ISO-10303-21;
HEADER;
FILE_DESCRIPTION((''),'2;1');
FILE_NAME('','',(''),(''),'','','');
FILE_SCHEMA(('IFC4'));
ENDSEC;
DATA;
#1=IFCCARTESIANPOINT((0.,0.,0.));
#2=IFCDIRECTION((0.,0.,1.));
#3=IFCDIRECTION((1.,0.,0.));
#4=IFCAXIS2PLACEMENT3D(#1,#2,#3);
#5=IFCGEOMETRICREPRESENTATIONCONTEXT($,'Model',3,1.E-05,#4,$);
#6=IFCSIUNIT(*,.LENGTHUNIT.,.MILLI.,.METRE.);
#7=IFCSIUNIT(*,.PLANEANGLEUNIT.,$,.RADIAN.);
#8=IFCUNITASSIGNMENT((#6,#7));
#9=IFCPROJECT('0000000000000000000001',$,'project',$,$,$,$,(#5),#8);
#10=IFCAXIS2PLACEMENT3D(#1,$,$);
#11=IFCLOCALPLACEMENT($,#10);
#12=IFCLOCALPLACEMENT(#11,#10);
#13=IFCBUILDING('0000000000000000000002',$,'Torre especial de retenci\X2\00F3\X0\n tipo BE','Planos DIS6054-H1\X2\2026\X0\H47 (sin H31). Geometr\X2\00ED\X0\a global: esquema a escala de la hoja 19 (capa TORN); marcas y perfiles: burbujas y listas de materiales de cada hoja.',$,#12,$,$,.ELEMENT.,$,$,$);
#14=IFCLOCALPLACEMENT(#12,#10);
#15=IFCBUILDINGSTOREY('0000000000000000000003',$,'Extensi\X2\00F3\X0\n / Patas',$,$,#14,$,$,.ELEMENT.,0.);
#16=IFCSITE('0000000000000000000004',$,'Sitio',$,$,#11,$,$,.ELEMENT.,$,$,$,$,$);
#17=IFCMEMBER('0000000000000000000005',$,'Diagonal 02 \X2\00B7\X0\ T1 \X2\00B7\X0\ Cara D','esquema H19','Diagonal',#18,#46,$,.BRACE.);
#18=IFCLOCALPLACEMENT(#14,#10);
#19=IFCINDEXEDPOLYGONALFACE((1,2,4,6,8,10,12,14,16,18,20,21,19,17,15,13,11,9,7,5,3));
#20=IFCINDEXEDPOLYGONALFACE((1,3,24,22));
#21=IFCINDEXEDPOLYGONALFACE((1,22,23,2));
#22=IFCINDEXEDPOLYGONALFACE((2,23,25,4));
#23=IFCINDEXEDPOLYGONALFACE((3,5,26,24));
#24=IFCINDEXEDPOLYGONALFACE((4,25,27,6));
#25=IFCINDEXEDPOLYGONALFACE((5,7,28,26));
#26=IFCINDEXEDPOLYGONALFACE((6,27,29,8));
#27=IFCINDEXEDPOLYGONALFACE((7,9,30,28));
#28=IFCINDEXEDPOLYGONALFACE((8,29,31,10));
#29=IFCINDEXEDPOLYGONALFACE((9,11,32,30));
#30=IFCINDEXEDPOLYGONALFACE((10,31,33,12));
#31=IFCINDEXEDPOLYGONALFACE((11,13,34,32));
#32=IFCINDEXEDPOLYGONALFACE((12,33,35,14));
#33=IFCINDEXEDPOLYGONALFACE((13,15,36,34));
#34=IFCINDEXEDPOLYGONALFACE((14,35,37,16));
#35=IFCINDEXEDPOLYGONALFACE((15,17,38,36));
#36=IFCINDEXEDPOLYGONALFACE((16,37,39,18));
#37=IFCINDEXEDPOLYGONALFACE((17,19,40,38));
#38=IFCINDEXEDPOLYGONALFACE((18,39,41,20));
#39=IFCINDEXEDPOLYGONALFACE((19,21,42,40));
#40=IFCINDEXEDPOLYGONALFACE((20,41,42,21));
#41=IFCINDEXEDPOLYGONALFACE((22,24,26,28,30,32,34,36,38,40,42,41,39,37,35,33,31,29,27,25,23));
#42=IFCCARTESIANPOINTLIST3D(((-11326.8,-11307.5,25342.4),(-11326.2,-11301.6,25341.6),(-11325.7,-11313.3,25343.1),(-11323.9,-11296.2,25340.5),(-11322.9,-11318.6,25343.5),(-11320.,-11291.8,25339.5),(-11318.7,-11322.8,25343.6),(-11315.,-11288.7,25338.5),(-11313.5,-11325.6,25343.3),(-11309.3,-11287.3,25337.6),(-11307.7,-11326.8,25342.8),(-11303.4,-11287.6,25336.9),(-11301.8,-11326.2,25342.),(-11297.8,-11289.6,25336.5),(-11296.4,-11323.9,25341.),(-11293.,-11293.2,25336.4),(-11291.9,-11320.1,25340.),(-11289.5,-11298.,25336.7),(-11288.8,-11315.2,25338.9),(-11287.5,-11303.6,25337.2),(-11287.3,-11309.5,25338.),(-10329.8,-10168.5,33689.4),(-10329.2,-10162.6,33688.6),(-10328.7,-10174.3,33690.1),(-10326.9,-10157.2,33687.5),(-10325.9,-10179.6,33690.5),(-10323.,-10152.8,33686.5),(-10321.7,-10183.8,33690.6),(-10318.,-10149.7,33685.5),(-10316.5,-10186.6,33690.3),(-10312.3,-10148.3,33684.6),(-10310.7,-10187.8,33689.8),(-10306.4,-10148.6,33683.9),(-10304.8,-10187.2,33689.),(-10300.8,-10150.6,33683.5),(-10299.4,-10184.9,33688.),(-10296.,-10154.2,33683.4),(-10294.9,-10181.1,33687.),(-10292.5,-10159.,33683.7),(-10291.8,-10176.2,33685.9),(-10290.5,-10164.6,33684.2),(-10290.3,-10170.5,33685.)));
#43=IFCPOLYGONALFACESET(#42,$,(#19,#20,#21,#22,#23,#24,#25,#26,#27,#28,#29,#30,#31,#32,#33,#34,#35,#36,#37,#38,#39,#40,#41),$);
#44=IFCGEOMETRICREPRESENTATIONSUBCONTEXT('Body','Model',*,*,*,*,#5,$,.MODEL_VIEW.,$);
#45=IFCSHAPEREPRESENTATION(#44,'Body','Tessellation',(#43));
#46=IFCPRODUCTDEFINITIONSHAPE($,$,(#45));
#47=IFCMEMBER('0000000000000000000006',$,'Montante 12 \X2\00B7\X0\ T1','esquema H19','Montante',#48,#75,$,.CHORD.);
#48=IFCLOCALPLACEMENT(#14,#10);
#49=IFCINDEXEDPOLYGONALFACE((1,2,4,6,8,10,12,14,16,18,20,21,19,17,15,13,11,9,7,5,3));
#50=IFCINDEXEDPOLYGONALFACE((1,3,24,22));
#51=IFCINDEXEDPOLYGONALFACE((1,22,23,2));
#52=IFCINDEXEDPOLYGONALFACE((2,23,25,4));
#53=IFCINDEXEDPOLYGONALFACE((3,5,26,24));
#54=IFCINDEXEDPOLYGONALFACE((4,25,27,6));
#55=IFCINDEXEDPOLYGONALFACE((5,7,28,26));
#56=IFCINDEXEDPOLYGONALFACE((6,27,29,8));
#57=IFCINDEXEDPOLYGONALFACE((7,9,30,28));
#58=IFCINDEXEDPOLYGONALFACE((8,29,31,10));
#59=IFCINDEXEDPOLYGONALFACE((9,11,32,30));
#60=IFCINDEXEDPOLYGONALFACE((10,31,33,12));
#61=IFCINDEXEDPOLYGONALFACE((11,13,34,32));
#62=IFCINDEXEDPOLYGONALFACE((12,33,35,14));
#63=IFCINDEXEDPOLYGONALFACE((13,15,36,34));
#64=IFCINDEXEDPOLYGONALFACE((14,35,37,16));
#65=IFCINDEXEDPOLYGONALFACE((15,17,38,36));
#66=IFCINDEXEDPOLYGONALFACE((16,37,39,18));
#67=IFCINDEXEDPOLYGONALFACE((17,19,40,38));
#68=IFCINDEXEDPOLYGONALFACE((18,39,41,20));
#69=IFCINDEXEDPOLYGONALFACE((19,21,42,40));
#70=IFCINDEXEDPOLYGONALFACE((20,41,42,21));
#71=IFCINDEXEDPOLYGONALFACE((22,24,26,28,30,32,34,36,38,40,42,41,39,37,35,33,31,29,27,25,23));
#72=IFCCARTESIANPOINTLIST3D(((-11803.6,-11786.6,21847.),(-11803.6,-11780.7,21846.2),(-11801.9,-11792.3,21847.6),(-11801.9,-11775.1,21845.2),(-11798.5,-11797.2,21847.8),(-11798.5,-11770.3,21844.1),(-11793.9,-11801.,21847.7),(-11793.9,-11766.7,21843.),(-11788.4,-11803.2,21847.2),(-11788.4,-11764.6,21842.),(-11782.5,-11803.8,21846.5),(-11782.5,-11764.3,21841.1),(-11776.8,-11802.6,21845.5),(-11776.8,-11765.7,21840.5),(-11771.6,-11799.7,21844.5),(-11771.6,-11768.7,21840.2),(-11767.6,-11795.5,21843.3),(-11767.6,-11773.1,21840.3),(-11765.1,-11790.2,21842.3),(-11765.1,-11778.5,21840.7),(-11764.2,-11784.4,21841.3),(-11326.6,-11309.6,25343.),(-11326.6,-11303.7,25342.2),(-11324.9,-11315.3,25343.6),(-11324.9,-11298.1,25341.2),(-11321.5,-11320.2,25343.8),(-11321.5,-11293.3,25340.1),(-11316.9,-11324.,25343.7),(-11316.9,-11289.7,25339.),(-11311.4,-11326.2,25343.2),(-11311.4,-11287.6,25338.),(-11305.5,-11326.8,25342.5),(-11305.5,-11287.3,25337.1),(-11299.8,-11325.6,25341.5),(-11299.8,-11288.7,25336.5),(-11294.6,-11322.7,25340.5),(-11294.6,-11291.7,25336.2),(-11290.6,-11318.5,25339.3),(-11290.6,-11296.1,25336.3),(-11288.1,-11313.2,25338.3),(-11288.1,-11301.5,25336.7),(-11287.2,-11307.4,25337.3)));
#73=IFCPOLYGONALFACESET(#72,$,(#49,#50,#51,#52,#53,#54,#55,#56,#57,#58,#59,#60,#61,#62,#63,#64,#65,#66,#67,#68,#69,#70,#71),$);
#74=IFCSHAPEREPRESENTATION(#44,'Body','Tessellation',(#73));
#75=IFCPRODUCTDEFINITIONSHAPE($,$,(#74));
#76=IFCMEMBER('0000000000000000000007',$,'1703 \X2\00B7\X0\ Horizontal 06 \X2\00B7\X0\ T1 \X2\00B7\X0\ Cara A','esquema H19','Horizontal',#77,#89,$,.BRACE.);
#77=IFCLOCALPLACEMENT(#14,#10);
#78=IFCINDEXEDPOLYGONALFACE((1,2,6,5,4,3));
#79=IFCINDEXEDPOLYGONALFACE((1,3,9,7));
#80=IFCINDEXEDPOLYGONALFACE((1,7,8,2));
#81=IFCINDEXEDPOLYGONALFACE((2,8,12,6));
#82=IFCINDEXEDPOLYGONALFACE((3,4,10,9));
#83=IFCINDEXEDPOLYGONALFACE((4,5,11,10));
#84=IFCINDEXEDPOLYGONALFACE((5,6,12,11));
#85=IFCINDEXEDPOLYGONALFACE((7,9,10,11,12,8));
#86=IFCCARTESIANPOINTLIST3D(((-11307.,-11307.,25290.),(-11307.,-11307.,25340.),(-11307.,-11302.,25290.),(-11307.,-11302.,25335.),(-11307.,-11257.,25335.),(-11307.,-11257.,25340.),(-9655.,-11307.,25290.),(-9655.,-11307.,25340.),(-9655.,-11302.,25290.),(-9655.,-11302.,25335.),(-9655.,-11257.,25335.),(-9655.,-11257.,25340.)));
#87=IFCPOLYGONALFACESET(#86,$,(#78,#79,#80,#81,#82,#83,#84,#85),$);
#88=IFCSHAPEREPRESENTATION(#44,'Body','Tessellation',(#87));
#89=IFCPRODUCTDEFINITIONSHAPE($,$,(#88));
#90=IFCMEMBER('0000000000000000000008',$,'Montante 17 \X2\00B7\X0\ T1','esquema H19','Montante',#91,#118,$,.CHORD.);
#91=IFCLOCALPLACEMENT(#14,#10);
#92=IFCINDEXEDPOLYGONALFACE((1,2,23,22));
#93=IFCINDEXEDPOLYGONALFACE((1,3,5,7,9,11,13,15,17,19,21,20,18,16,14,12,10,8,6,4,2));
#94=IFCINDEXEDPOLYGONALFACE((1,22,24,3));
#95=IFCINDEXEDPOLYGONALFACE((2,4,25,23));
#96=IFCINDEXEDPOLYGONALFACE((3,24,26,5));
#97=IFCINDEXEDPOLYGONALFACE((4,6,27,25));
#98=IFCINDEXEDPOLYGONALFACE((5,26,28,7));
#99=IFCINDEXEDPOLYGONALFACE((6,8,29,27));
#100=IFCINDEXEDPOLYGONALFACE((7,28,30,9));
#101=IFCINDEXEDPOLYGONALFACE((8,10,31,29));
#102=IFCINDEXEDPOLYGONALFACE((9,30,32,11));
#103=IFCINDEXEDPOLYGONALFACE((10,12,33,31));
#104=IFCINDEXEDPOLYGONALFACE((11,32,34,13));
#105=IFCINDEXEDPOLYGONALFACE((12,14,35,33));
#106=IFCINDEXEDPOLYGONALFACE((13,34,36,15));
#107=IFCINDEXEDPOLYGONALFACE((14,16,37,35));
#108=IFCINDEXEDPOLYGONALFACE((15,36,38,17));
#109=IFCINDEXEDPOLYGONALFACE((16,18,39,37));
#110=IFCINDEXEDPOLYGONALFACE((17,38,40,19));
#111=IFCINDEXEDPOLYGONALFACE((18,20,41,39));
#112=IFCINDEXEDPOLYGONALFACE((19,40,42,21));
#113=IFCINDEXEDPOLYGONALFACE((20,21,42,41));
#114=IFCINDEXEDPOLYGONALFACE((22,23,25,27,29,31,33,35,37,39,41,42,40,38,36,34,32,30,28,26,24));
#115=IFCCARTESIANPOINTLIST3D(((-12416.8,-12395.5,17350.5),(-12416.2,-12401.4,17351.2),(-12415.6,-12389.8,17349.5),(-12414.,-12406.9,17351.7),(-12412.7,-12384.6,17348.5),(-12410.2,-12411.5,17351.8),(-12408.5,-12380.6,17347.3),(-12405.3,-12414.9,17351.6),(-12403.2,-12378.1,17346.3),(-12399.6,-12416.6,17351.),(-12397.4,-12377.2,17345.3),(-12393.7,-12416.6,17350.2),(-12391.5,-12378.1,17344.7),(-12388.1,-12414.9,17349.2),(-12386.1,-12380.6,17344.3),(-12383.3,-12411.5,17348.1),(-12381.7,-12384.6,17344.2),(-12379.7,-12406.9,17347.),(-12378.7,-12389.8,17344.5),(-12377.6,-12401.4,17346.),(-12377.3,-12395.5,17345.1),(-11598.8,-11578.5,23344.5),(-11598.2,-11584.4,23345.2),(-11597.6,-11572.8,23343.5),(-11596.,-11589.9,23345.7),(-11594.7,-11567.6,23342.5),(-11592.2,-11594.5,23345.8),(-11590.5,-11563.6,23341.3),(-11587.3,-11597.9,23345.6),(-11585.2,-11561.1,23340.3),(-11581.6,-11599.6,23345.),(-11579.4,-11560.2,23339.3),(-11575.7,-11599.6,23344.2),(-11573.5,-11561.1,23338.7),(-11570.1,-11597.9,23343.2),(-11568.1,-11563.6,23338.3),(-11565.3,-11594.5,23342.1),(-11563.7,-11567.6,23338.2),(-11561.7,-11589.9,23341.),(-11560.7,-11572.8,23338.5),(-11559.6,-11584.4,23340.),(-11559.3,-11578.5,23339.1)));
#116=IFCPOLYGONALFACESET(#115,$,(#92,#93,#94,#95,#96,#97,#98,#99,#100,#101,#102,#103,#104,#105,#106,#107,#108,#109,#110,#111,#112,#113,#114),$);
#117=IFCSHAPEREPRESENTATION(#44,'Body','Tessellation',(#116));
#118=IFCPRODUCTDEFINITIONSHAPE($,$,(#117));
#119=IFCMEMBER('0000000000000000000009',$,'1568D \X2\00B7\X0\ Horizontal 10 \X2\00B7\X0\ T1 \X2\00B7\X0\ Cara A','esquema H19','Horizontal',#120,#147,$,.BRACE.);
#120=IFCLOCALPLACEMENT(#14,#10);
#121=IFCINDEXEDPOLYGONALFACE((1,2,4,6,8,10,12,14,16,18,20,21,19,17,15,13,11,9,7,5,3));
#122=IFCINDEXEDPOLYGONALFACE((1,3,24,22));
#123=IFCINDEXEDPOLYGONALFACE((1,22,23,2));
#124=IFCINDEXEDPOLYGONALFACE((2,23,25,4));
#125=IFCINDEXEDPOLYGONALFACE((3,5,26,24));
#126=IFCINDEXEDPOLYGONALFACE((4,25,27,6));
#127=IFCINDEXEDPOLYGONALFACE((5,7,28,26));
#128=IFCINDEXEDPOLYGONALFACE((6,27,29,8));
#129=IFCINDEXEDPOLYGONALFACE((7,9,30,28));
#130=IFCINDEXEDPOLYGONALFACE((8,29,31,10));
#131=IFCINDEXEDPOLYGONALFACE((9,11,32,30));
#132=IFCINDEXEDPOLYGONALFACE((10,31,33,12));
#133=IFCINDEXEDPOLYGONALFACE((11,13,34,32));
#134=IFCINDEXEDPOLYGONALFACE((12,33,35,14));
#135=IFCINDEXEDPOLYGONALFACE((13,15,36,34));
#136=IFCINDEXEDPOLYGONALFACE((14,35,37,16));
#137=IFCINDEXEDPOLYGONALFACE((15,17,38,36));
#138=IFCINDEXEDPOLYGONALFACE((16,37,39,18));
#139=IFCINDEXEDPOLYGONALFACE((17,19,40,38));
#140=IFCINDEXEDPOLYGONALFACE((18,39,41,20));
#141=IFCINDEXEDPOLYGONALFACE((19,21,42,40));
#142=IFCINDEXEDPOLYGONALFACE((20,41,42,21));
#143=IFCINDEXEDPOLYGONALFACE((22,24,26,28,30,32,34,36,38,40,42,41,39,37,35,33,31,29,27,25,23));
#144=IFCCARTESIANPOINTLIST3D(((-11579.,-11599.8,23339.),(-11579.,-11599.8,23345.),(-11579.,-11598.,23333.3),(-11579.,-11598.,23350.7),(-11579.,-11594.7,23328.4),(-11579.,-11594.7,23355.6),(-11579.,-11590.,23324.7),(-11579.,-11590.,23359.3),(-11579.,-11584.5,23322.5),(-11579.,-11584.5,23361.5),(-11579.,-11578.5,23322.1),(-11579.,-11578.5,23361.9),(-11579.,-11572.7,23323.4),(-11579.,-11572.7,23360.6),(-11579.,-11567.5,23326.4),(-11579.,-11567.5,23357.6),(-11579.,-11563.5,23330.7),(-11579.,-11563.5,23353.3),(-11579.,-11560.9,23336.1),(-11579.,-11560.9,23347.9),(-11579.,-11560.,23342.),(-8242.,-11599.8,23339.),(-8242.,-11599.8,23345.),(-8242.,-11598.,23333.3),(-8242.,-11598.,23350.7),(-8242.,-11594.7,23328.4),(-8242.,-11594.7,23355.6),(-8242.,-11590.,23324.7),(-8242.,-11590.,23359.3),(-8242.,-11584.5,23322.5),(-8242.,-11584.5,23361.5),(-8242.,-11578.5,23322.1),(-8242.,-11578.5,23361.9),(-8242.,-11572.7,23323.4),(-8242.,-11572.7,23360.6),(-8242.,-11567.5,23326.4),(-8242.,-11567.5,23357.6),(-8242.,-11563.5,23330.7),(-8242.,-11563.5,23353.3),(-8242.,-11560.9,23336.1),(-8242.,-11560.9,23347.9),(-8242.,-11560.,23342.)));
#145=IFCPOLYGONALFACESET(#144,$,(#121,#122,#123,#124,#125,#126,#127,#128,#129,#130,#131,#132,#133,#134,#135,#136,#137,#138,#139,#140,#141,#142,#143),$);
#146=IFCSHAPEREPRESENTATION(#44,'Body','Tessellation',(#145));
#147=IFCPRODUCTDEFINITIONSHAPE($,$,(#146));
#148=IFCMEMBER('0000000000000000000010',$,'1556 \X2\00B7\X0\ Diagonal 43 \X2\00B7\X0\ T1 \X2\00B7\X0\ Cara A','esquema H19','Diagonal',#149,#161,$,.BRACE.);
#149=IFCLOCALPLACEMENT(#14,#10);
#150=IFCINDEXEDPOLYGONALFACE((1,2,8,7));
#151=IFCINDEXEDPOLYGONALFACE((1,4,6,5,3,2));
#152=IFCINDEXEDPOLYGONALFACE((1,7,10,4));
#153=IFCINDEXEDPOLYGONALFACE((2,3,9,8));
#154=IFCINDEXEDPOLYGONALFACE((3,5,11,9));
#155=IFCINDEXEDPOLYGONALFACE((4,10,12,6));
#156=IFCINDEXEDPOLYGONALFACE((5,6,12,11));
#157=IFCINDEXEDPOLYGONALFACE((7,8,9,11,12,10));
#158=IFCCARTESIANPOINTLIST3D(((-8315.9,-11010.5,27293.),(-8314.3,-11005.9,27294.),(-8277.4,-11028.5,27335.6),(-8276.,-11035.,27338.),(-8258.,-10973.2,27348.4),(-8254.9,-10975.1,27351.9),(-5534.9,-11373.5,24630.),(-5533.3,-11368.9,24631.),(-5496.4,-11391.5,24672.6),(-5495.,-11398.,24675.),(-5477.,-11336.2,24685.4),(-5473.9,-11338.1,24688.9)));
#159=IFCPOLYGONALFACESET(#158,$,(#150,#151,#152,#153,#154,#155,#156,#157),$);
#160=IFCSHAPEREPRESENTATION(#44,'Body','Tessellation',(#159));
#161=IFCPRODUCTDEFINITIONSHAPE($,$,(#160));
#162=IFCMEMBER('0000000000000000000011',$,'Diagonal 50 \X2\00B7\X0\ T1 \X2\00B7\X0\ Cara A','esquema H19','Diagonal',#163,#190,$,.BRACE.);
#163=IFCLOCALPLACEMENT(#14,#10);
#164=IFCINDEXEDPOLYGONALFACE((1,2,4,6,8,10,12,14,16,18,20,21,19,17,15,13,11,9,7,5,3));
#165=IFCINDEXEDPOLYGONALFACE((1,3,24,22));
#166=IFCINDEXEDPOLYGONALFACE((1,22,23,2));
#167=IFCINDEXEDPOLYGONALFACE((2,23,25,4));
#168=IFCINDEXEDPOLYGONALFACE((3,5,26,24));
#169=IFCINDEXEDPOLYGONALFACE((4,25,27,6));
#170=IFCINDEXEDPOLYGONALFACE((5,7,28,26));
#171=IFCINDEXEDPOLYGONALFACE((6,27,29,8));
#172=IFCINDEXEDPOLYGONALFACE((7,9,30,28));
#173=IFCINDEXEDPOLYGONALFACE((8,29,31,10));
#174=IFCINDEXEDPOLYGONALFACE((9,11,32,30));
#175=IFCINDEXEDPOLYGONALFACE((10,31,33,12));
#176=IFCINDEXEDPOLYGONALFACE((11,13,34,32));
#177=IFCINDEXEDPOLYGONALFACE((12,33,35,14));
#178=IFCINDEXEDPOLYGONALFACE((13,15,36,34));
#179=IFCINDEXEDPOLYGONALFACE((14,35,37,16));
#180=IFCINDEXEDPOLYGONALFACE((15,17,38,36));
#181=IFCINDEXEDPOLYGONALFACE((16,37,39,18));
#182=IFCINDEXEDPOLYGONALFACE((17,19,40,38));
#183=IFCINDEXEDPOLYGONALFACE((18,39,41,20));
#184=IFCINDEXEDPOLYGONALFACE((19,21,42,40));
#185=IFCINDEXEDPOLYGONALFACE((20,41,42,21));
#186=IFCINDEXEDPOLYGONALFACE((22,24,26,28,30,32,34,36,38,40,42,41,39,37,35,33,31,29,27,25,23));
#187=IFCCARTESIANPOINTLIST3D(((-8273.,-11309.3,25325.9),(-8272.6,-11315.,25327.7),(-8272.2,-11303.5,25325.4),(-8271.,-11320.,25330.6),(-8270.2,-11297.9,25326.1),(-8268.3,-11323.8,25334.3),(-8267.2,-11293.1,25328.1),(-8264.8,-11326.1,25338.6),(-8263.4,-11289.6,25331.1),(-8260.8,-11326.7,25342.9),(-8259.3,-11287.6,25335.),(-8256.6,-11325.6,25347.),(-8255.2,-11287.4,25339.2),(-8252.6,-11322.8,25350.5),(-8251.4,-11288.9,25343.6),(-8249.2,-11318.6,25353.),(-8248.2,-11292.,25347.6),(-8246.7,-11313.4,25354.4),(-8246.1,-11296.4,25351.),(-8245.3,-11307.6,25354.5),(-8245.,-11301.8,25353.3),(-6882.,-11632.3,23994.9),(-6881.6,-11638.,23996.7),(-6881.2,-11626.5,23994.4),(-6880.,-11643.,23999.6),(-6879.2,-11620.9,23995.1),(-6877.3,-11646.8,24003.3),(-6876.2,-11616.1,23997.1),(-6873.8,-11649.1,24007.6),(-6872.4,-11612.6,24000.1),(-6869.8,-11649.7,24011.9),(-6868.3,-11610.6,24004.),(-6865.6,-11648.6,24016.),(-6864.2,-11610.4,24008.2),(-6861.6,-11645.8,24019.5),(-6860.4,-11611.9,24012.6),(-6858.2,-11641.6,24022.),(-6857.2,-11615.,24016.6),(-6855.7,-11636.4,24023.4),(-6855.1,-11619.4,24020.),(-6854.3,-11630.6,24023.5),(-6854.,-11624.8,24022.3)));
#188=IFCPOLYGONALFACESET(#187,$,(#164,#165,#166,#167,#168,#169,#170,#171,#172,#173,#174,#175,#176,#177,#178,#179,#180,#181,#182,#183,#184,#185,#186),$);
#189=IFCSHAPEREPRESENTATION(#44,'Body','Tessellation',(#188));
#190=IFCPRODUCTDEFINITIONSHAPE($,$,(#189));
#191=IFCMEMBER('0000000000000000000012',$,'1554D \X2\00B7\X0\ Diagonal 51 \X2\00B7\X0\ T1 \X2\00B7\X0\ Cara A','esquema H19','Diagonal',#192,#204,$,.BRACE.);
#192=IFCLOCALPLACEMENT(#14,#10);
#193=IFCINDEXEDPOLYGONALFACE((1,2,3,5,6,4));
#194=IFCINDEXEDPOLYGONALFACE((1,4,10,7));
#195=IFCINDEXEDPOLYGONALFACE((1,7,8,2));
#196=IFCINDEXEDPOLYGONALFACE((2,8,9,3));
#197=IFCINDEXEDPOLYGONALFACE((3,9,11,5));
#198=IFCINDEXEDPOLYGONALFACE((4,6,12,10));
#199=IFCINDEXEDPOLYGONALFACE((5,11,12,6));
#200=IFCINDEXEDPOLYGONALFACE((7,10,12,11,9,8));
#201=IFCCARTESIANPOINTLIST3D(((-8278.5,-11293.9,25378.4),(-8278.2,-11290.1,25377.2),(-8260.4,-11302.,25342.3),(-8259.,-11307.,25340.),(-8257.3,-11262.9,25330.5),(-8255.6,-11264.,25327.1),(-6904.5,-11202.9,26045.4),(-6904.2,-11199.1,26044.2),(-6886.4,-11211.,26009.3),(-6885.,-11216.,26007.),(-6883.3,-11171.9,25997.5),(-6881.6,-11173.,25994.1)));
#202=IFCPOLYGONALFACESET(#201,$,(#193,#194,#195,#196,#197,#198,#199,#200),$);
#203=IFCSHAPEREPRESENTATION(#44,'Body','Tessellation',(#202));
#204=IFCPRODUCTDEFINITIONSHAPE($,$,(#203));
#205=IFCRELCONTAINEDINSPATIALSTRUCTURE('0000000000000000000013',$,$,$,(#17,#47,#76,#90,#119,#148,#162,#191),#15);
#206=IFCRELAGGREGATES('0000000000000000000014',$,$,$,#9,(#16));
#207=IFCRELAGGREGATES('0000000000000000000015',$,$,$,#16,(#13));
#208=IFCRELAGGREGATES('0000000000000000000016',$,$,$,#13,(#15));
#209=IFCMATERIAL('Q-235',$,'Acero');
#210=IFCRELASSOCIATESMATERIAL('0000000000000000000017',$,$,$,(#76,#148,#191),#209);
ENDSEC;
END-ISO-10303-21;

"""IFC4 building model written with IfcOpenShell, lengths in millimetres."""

from ifc_helpers import new_model, si_unit, frame, frame_2d, origin, origin_with_axes, place, context, subcontext, project, spatial, circle, l_section, extrude, material, element, save


model = new_model("IFC4")

# Units and contexts
model_context = context("Model", 3, precision=1e-05, world=origin_with_axes())
body_context = subcontext(model_context, "Body", "Model", "MODEL_VIEW")
ifc_project = project(units=[si_unit("LENGTHUNIT", "METRE", prefix="MILLI"), si_unit("PLANEANGLEUNIT", "RADIAN")], contexts=[model_context])

# Site, building, storey
site_placement = place(None, origin())
site = spatial("IfcSite", under=ifc_project, at=site_placement, Name="Sitio", CompositionType="ELEMENT")
building_placement = place(site_placement, origin())
building = spatial("IfcBuilding", under=site, at=building_placement, Name="Torre especial de retención tipo BE", Description="Planos DIS6054-H1…H47 (sin H31). Geometría global: esquema a escala de la hoja 19 (capa TORN); marcas y perfiles: burbujas y listas de materiales de cada hoja.", CompositionType="ELEMENT")
storey_placement = place(building_placement, origin())
storey = spatial("IfcBuildingStorey", under=building, at=storey_placement, Name="Extensión / Patas", CompositionType="ELEMENT", Elevation=0.0)

# Members
member_1_placement = place(storey_placement, frame((-11307.0, -11307.0, 25340.0), z_axis=(0.117527, 0.134266, 0.983951), x_axis=(0.699687, 0.691923, -0.177991)))
element("IfcMember", 1, at=member_1_placement, inside=storey, Name="Diagonal 02 · T1 · Cara D", Description="esquema H19", ObjectType="Diagonal", PredefinedType="BRACE", context=body_context, shape_type="SweptSolid", body=[
    extrude(circle(Radius=20.0), None, (0.0, 0.0, 1.0), 8483.1),
])
member_2_placement = place(storey_placement, frame((-11784.0, -11784.0, 21844.0), z_axis=(0.13397, 0.13397, 0.981888), x_axis=(0.990985, -0.018111, -0.132741)))
element("IfcMember", 2, at=member_2_placement, inside=storey, Name="Montante 12 · T1", Description="esquema H19", ObjectType="Montante", PredefinedType="CHORD", context=body_context, shape_type="SweptSolid", body=[
    extrude(circle(Radius=20.0), None, (0.0, 0.0, 1.0), 3560.5),
])
ifc_material_1 = material(Name="Q-235", Category="Acero")
member_3_placement = place(storey_placement, frame((-9655.0, -11307.0, 25340.0), z_axis=(-1.0, 0.0, 0.0), x_axis=(0.0, 1.0, 0.0)))
element("IfcMember", 3, at=member_3_placement, inside=storey, material=ifc_material_1, Name="1703 · Horizontal 06 · T1 · Cara A", Description="esquema H19", ObjectType="Horizontal", PredefinedType="BRACE", context=body_context, shape_type="SweptSolid", body=[
    extrude(l_section(Depth=50.0, Width=50.0, Thickness=5.0, at=frame_2d((25.0, 25.0))), None, (0.0, 0.0, 1.0), 1652.0),
])
member_4_placement = place(storey_placement, frame((-11579.0, -11580.0, 23342.0), z_axis=(-0.134, -0.133836, -0.981902), x_axis=(-0.018097, 0.991003, -0.132607)))
element("IfcMember", 4, at=member_4_placement, inside=storey, Name="Montante 17 · T1", Description="esquema H19", ObjectType="Montante", PredefinedType="CHORD", context=body_context, shape_type="SweptSolid", body=[
    extrude(circle(Radius=20.0), None, (0.0, 0.0, 1.0), 6104.5),
])
member_5_placement = place(storey_placement, frame((-11579.0, -11580.0, 23342.0), z_axis=(1.0, 0.0, 0.0), x_axis=(0.0, 1.0, 0.0)))
element("IfcMember", 5, at=member_5_placement, inside=storey, Name="1568D · Horizontal 10 · T1 · Cara A", Description="esquema H19", ObjectType="Horizontal", PredefinedType="BRACE", context=body_context, shape_type="SweptSolid", body=[
    extrude(circle(Radius=20.0), None, (0.0, 0.0, 1.0), 3337.0),
])
member_6_placement = place(storey_placement, frame((-5495.0, -11398.0, 24675.0), z_axis=(-0.719075, 0.09386, 0.688564), x_axis=(0.324743, 0.921381, 0.213537)))
element("IfcMember", 6, at=member_6_placement, inside=storey, material=ifc_material_1, Name="1556 · Diagonal 43 · T1 · Cara A", Description="esquema H19", ObjectType="Diagonal", PredefinedType="BRACE", context=body_context, shape_type="SweptSolid", body=[
    extrude(l_section(Depth=65.0, Width=65.0, Thickness=5.0, at=frame_2d((32.5, 32.5))), None, (0.0, 0.0, 1.0), 3867.5),
])
member_7_placement = place(storey_placement, frame((-6868.0, -11630.0, 24009.0), z_axis=(-0.712559, 0.165461, 0.681823), x_axis=(0.381984, 0.906632, 0.179186)))
element("IfcMember", 7, at=member_7_placement, inside=storey, Name="Diagonal 50 · T1 · Cara A", Description="esquema H19", ObjectType="Diagonal", PredefinedType="BRACE", context=body_context, shape_type="SweptSolid", body=[
    extrude(circle(Radius=20.0), None, (0.0, 0.0, 1.0), 1952.1),
])
member_8_placement = place(storey_placement, frame((-8259.0, -11307.0, 25340.0), z_axis=(0.898011, 0.059475, 0.435934), x_axis=(0.076285, 0.954767, -0.287405)))
element("IfcMember", 8, at=member_8_placement, inside=storey, material=ifc_material_1, Name="1554D · Diagonal 51 · T1 · Cara A", Description="esquema H19", ObjectType="Diagonal", PredefinedType="BRACE", context=body_context, shape_type="SweptSolid", body=[
    extrude(l_section(Depth=45.0, Width=45.0, Thickness=4.0, at=frame_2d((22.5, 22.5))), None, (0.0, 0.0, 1.0), 1530.0),
])

save(model, "model.ifc")
